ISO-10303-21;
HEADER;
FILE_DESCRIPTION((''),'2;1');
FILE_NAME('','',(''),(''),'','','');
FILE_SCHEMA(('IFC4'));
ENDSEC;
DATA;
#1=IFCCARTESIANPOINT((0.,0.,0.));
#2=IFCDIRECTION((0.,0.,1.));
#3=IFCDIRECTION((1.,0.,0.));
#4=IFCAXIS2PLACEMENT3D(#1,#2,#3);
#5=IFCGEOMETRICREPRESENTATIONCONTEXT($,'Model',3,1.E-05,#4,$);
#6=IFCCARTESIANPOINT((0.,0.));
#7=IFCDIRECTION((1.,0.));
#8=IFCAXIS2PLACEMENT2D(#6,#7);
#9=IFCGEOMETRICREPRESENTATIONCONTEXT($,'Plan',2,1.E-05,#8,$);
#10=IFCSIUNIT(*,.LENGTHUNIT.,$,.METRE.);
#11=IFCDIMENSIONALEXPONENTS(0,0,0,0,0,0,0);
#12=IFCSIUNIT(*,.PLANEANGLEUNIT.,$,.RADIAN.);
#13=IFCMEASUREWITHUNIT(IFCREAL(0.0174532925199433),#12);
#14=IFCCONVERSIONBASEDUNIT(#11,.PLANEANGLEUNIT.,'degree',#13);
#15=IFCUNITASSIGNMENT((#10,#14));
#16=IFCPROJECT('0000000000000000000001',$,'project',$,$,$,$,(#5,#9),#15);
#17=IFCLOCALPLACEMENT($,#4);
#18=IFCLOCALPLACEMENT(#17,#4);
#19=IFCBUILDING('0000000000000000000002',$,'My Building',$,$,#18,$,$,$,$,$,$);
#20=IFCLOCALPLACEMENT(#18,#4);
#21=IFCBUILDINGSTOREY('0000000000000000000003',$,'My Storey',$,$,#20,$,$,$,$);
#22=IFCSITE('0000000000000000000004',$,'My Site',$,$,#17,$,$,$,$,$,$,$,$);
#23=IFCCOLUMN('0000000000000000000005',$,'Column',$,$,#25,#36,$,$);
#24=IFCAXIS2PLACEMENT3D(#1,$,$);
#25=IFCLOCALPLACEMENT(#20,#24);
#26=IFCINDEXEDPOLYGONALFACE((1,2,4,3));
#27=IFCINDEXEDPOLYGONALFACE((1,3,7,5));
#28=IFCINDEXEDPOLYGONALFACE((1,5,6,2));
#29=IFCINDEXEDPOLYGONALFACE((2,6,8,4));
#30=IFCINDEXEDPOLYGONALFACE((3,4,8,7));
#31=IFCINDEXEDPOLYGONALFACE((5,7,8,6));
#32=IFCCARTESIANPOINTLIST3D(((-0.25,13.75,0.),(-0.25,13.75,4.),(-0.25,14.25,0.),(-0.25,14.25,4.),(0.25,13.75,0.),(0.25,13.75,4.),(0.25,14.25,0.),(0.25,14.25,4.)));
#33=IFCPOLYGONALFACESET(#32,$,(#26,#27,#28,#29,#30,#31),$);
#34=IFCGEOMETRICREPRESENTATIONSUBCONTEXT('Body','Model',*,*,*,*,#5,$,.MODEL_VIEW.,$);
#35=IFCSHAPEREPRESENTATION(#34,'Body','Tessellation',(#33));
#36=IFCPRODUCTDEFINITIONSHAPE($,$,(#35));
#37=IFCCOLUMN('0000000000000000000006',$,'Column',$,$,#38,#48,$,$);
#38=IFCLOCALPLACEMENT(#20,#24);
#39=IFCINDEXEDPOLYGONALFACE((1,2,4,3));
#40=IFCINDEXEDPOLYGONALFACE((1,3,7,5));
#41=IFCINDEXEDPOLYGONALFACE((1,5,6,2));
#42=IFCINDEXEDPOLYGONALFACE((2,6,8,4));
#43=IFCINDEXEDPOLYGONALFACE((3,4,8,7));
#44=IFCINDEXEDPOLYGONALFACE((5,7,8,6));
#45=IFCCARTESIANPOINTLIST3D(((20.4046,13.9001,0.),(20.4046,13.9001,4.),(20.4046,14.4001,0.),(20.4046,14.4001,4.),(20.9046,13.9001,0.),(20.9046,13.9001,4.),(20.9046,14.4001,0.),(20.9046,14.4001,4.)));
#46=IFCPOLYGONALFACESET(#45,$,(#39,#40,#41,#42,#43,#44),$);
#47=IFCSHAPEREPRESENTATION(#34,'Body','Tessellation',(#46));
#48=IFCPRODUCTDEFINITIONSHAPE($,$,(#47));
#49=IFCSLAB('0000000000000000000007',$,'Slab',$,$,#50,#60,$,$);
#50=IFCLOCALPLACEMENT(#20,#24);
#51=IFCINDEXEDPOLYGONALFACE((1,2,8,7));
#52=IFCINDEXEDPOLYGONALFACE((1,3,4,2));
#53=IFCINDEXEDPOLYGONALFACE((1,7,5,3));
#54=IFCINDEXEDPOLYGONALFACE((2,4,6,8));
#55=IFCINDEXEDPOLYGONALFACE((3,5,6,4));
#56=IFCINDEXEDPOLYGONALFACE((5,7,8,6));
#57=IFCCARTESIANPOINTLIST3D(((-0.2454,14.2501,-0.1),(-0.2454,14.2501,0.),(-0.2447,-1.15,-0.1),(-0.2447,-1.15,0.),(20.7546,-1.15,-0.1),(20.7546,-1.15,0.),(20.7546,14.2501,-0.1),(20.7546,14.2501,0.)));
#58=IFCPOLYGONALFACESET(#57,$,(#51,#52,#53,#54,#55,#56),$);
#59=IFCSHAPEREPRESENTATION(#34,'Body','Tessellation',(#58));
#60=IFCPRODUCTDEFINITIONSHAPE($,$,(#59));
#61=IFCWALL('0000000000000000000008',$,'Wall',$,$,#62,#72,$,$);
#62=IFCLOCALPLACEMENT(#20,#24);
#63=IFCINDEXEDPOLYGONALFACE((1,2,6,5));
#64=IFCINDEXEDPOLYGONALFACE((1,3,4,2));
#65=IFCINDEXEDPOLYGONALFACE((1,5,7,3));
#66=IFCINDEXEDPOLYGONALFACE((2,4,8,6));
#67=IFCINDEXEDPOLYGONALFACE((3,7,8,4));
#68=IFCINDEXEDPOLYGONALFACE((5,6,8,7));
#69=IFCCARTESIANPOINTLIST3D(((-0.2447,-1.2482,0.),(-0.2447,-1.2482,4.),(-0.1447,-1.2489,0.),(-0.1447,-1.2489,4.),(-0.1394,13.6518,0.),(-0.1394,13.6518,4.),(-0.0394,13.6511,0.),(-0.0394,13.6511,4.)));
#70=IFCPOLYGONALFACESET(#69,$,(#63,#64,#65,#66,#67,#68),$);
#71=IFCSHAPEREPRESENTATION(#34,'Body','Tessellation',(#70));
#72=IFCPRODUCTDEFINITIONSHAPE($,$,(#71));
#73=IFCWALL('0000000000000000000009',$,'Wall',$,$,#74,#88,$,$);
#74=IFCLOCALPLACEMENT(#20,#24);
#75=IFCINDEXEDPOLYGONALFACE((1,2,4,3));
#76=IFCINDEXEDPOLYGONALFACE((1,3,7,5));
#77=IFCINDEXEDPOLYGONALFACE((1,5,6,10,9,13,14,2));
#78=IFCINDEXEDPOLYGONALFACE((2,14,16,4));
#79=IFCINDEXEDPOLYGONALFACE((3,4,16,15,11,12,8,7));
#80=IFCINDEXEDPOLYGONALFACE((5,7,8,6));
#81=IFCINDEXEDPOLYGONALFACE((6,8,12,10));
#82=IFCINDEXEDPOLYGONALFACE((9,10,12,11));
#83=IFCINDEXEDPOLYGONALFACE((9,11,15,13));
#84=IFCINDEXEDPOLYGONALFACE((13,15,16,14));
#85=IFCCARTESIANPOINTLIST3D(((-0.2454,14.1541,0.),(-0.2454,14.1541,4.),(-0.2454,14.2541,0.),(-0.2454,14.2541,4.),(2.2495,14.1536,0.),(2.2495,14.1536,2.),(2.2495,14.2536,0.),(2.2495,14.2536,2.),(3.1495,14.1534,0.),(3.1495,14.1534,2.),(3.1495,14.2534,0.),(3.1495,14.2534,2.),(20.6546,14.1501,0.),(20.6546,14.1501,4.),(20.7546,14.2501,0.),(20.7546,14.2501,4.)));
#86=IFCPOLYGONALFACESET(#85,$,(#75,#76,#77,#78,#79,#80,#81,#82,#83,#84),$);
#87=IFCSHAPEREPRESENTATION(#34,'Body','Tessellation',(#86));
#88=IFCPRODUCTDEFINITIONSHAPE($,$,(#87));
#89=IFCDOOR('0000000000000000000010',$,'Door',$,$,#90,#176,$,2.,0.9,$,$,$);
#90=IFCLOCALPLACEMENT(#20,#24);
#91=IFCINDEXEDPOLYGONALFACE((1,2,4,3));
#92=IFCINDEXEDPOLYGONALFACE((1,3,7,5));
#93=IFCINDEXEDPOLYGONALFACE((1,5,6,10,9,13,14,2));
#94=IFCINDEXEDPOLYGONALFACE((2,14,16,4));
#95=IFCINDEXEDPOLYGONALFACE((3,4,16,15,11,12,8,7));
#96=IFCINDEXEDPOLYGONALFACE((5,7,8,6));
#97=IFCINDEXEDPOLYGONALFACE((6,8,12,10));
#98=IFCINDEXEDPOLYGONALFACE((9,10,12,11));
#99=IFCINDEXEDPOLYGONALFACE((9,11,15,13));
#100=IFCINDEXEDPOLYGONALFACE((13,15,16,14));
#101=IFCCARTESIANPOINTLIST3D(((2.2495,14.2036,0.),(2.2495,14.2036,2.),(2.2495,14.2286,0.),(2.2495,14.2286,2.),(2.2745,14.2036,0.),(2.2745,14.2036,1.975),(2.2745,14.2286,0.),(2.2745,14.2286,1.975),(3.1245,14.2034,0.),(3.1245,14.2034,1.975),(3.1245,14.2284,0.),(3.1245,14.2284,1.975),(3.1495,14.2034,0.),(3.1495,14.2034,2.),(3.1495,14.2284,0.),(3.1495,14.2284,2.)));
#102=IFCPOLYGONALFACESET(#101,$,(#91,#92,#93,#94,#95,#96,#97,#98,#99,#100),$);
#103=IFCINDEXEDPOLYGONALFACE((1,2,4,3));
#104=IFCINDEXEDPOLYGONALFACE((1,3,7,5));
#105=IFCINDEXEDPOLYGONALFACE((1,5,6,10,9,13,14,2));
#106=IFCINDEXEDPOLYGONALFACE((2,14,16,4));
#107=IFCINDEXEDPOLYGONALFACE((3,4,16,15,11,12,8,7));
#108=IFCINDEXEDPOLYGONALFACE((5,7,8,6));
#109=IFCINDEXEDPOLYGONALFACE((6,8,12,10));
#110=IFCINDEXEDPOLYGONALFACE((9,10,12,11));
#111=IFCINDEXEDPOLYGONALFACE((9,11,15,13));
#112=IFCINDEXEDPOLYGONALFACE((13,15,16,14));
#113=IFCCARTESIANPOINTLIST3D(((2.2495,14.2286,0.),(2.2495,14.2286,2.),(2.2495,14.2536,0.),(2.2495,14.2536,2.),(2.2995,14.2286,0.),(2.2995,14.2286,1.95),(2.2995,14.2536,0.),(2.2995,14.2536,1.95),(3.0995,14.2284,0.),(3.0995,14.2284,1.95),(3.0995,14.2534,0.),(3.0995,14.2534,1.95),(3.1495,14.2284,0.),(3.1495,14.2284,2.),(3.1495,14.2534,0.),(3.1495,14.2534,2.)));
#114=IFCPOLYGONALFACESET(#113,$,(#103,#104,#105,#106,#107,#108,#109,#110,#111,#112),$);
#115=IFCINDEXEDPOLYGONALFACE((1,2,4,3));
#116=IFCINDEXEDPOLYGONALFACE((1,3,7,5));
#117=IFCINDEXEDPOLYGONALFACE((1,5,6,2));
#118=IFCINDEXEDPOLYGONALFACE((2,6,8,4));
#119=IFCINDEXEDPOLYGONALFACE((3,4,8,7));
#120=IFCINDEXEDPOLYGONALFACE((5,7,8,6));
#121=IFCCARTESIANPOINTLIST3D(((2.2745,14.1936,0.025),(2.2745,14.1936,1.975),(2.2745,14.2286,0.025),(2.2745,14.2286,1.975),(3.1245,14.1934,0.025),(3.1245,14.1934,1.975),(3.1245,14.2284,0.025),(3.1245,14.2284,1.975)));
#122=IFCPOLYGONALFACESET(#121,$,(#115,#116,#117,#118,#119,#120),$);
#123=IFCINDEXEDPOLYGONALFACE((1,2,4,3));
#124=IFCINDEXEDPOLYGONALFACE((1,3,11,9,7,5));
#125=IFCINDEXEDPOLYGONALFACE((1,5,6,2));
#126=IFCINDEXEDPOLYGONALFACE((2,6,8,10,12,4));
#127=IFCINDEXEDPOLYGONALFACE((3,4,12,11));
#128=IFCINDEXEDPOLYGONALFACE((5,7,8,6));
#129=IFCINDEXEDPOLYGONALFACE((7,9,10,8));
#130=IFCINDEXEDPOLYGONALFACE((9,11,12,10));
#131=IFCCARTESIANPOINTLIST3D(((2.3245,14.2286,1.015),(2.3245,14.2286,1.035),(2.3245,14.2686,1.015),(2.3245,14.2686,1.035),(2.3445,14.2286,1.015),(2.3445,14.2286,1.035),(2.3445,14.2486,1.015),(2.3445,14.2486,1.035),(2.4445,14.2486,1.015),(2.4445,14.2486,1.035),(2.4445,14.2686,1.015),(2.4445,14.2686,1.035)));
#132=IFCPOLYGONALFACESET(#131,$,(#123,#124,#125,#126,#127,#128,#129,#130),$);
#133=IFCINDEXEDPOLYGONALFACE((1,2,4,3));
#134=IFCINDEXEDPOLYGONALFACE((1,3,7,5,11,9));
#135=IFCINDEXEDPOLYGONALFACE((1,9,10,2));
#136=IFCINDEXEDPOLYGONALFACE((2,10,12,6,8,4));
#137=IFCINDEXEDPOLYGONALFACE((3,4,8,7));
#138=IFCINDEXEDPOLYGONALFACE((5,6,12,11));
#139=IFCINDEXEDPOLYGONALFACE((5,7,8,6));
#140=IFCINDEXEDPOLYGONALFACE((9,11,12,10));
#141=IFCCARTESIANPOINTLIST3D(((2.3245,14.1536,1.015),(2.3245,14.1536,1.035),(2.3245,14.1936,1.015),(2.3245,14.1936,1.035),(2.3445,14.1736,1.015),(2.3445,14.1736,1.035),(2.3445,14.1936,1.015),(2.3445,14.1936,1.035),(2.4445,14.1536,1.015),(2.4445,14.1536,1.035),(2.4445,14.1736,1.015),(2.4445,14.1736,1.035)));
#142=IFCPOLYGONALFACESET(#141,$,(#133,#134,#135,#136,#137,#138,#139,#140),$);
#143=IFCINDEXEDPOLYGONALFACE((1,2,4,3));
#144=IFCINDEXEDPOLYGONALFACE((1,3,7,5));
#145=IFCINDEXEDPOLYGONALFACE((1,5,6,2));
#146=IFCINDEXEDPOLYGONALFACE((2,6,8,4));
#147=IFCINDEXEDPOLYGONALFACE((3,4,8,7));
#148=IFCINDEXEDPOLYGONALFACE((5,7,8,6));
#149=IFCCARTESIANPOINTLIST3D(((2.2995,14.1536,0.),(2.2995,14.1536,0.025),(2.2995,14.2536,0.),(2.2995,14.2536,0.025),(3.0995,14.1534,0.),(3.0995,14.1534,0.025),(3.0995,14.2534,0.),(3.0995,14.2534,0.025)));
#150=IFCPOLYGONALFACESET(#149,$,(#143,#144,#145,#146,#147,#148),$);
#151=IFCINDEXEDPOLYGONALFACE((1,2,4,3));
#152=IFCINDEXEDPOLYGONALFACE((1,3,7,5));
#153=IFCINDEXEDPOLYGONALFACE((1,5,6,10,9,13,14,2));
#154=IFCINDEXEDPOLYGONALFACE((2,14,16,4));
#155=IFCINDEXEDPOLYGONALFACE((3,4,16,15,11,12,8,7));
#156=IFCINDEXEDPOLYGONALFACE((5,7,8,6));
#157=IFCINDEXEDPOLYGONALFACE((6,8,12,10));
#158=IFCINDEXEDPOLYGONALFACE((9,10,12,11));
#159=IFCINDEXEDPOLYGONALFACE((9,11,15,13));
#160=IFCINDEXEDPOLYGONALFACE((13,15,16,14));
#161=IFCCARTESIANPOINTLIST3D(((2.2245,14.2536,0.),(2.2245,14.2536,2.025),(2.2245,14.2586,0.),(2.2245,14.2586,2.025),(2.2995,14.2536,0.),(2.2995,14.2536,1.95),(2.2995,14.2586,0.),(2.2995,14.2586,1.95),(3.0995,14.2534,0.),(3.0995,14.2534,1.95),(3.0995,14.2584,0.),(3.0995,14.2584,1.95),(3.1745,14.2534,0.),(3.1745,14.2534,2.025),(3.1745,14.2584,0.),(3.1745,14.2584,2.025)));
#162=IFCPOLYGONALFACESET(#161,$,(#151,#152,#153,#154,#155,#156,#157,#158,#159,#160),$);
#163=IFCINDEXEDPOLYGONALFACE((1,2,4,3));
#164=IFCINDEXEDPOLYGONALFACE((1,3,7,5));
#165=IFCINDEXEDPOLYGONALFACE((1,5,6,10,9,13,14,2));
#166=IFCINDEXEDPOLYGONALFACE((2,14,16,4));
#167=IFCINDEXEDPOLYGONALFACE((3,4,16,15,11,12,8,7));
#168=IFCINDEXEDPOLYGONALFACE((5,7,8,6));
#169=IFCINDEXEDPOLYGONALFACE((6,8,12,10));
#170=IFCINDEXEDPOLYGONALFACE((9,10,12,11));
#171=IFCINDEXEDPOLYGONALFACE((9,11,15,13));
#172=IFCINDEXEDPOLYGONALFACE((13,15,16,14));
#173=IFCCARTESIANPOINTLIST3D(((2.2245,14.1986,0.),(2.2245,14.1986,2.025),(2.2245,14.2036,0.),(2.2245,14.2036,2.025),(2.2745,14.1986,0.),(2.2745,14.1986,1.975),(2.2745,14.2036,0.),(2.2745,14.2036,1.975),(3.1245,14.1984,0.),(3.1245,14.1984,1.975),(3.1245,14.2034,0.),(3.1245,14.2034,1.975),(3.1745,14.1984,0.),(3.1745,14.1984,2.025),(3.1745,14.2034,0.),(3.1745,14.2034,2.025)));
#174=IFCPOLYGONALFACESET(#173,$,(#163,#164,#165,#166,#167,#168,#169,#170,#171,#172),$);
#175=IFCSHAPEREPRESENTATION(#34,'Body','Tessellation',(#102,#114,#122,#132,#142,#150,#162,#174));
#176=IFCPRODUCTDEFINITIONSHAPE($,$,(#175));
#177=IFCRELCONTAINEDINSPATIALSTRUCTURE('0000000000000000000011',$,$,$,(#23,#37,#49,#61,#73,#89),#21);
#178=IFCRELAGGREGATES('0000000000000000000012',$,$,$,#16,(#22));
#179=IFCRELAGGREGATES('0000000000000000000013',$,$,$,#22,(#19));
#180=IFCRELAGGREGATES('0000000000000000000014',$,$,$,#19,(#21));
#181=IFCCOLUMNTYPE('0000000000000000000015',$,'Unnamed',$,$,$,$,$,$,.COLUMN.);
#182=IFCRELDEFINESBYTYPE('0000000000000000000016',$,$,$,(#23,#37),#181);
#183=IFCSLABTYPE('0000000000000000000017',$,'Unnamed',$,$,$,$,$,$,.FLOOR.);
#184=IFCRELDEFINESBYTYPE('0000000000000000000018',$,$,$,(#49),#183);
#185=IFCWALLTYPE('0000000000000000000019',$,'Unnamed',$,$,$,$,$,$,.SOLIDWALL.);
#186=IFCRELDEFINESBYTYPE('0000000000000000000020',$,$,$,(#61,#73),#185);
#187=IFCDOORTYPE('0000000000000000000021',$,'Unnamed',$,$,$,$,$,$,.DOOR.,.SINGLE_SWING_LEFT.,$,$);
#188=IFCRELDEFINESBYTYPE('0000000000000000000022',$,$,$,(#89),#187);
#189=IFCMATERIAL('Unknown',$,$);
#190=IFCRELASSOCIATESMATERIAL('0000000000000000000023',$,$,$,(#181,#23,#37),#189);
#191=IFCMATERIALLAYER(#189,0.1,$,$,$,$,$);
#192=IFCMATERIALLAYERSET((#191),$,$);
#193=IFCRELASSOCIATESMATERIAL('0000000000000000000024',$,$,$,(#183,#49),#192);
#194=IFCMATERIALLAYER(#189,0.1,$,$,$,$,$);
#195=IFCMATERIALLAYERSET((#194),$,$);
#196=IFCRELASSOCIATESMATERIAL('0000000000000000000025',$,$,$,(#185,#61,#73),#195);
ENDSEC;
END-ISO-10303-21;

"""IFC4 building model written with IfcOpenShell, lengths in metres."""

from ifc_helpers import new_model, entity, si_unit, converted_unit, frame, origin_with_axes, origin_2d_with_axis, place, context, subcontext, project, spatial, line, indexed_curve, rectangle, outline, extrude, shape, source, transform, mapped, material, layer, layer_set, layer_usage, material_profile, profile_set, profile_usage, type_object, type_shapes, element, fill, save


model = new_model("IFC4")

# Units and contexts
model_context = context("Model", 3, precision=1e-05, world=origin_with_axes())
plan_context = context("Plan", 2, precision=1e-05, world=origin_2d_with_axis())
body_context_1 = subcontext(model_context, "Body", "Model", "MODEL_VIEW")
body_context_2 = subcontext(plan_context, "Body", "Plan", "PLAN_VIEW")
ifc_project = project(units=[si_unit("LENGTHUNIT", "METRE"), converted_unit("PLANEANGLEUNIT", "degree", entity("IfcReal", 0.0174532925199433), si_unit("PLANEANGLEUNIT", "RADIAN"), dimensions=[0, 0, 0, 0, 0, 0, 0])], contexts=[model_context, plan_context])

# Site, building, storey
site_placement = place(None, origin_with_axes())
site = spatial("IfcSite", under=ifc_project, at=site_placement, Name="My Site")
building_placement = place(site_placement, origin_with_axes())
building = spatial("IfcBuilding", under=site, at=building_placement, Name="My Building")
storey_placement = place(building_placement, origin_with_axes())
storey = spatial("IfcBuildingStorey", under=building, at=storey_placement, Name="My Storey")

# Columns
ifc_material = material(Name="Unknown")
ifc_material_profile_1 = material_profile(ifc_material, rectangle(XDim=0.5, YDim=0.5))
ifc_profile_set_1 = profile_set([ifc_material_profile_1])
ifc_profile_usage_1 = profile_usage(ifc_profile_set_1, cardinal=5)
column_type = type_object("IfcColumnType", Name="Unnamed", PredefinedType="COLUMN", material=ifc_profile_set_1)
column_1_placement = place(storey_placement, frame((0.0, 14.0, 0.0), z_axis=(0.0, 0.0, 1.0), x_axis=(1.0, 0.0, 0.0)))
element("IfcColumn", 1, at=column_1_placement, inside=storey, type_object=column_type, material=ifc_profile_usage_1, Name="Column", context=body_context_1, shape_type="SweptSolid", body=[
    extrude(rectangle(XDim=0.5, YDim=0.5), origin_with_axes(), (0.0, 0.0, 1.0), 4.0),
])
ifc_profile_usage_2 = profile_usage(ifc_profile_set_1, cardinal=5)
column_2_placement = place(storey_placement, frame((20.6546, 14.1501, 0.0), z_axis=(0.0, 0.0, 1.0), x_axis=(1.0, 0.0, 0.0)))
element("IfcColumn", 2, at=column_2_placement, inside=storey, type_object=column_type, material=ifc_profile_usage_2, Name="Column", context=body_context_1, shape_type="SweptSolid", body=[
    extrude(rectangle(XDim=0.5, YDim=0.5), origin_with_axes(), (0.0, 0.0, 1.0), 4.0),
])

# Slab
ifc_layer_1 = layer(ifc_material, 0.1)
ifc_layer_set_1 = layer_set([ifc_layer_1])
ifc_layer_usage_1 = layer_usage(ifc_layer_set_1, "AXIS3", "POSITIVE", -0.1)
slab_type = type_object("IfcSlabType", Name="Unnamed", PredefinedType="FLOOR", material=ifc_layer_set_1)
slab_placement = place(storey_placement, frame((-0.2454, 14.2501, 0.0), z_axis=(0.0, 0.0, 1.0), x_axis=(1.0, 0.0, 0.0)))
element("IfcSlab", 3, at=slab_placement, inside=storey, type_object=slab_type, material=ifc_layer_usage_1, Name="Slab", context=body_context_1, shape_type="SweptSolid", body=[
    extrude(outline(indexed_curve([(0.0, 0.0), (21.0, 0.0), (21.0, -15.4), (0.0007, -15.4), (0.0, 0.0)])), frame((0.0, 0.0, -0.1), z_axis=(0.0, 0.0, 1.0), x_axis=(1.0, 0.0, 0.0)), (0.0, 0.0, 1.0), 0.1),
])

# Wall
ifc_layer_2 = layer(ifc_material, 0.1)
ifc_layer_set_2 = layer_set([ifc_layer_2])
ifc_layer_usage_2 = layer_usage(ifc_layer_set_2, "AXIS2", "POSITIVE", 0.0)
wall_type = type_object("IfcWallType", Name="Unnamed", PredefinedType="SOLIDWALL", material=ifc_layer_set_2)
wall_1_placement = place(storey_placement, frame((-0.1394, 13.6518, 0.0), z_axis=(0.0, 0.0, 1.0), x_axis=(-0.007068, -0.999975, 0.0)))
element("IfcWall", 4, at=wall_1_placement, inside=storey, type_object=wall_type, material=ifc_layer_usage_2, Name="Wall", context=body_context_1, shape_type="SweptSolid", body=[
    extrude(outline(indexed_curve([(0.0, 0.0), (0.0, 0.1), (14.9004, 0.1), (14.9004, 0.0)], segments=[line(1, 2, 3, 4, 1)])), origin_with_axes(), (0.0, 0.0, 1.0), 4.0),
])

# Wall, opening, door
ifc_layer_usage_3 = layer_usage(ifc_layer_set_2, "AXIS2", "POSITIVE", 0.0)
wall_2_placement = place(storey_placement, frame((20.7546, 14.2501, 0.0), z_axis=(0.0, 0.0, 1.0), x_axis=(-1.0, 0.000191, 0.0)))
wall_2 = element("IfcWall", 5, at=wall_2_placement, inside=storey, type_object=wall_type, material=ifc_layer_usage_3, Name="Wall", context=body_context_1, shape_type="SweptSolid", body=[
    extrude(outline(indexed_curve([(0.0, 0.0), (0.1, 0.1), (21.0, 0.1), (21.0, 0.0)], segments=[line(1, 2, 3, 4, 1)])), origin_with_axes(), (0.0, 0.0, 1.0), 4.0),
])
shared_shape_1 = source(origin_with_axes(), body_context_1, "Body", "SweptSolid", [
    extrude(outline(indexed_curve([(0.0, 0.0), (0.9, 0.0), (0.9, 2.0), (0.0, 2.0)], segments=[line(1, 2, 3, 4, 1)])), frame((0.0, -0.6, 0.0), z_axis=(0.0, -1.0, 0.0), x_axis=(1.0, 0.0, 0.0)), (0.0, 0.0, -1.0), 1.2),
])
opening_1_placement = place(wall_2_placement, frame((17.6051, 0.0, 0.0), z_axis=(0.0, 0.0, 1.0), x_axis=(1.0, 0.0, 0.0)))
opening_1 = element("IfcOpeningElement", 6, at=opening_1_placement, cuts=wall_2, PredefinedType="OPENING", context=body_context_1, shape_type="MappedRepresentation", body=[
    mapped(shared_shape_1, transform((0.0, 0.0, 0.0), x_axis=(1.0, 0.0, 0.0), y_axis=(0.0, 1.0, 0.0), z_axis=(0.0, 0.0, 1.0), scale=1.0)),
])
door_type = type_object("IfcDoorType", Name="Unnamed", OperationType="SINGLE_SWING_LEFT", PredefinedType="DOOR")
shared_shape_2 = source(origin_with_axes(), body_context_1, "Body", "SweptSolid", [
    extrude(outline(indexed_curve([(0.0, 0.0), (0.0, 2.0), (0.9, 2.0), (0.9, 0.0), (0.875, 0.0), (0.875, 1.975), (0.025, 1.975), (0.025, 0.0)], segments=[line(1, 2, 3, 4, 5, 6, 7, 8, 1)])), frame((0.0, 0.025, 0.0), z_axis=(0.0, -1.0, 0.0), x_axis=(1.0, 0.0, 0.0)), (0.0, 0.0, -1.0), 0.025),
    extrude(outline(indexed_curve([(0.0, 0.0), (0.0, 2.0), (0.9, 2.0), (0.9, 0.0), (0.85, 0.0), (0.85, 1.95), (0.05, 1.95), (0.05, 0.0)], segments=[line(1, 2, 3, 4, 5, 6, 7, 8, 1)])), frame((0.0, 0.0, 0.0), z_axis=(0.0, -1.0, 0.0), x_axis=(1.0, 0.0, 0.0)), (0.0, 0.0, -1.0), 0.025),
    extrude(outline(indexed_curve([(0.0, 0.0), (0.85, 0.0), (0.85, 0.035), (0.0, 0.035)], segments=[line(1, 2, 3, 4, 1)])), frame((0.025, 0.025, 0.025), z_axis=(0.0, 0.0, 1.0), x_axis=(1.0, 0.0, 0.0)), (0.0, 0.0, 1.0), 1.95),
    extrude(outline(indexed_curve([(0.0, 0.0), (0.0, -0.04), (-0.12, -0.04), (-0.12, -0.02), (-0.02, -0.02), (-0.02, 0.0)], segments=[line(1, 2, 3, 4, 5, 6, 1)])), frame((0.825, 0.025, 1.015), z_axis=(0.0, 0.0, 1.0), x_axis=(1.0, 0.0, 0.0)), (0.0, 0.0, 1.0), 0.02),
    extrude(outline(indexed_curve([(0.0, 0.0), (0.0, 0.04), (-0.12, 0.04), (-0.12, 0.02), (-0.02, 0.02), (-0.02, 0.0)], segments=[line(1, 2, 3, 4, 5, 6, 1)])), frame((0.825, 0.06, 1.015), z_axis=(0.0, 0.0, 1.0), x_axis=(1.0, 0.0, 0.0)), (0.0, 0.0, 1.0), 0.02),
    extrude(outline(indexed_curve([(0.0, 0.0), (0.8, 0.0), (0.8, 0.1), (0.0, 0.1)], segments=[line(1, 2, 3, 4, 1)])), frame((0.05, 0.0, 0.0), z_axis=(0.0, 0.0, 1.0), x_axis=(1.0, 0.0, 0.0)), (0.0, 0.0, 1.0), 0.025),
    extrude(outline(indexed_curve([(0.0, 0.0), (0.0, 2.025), (0.95, 2.025), (0.95, 0.0), (0.875, 0.0), (0.875, 1.95), (0.075, 1.95), (0.075, 0.0)], segments=[line(1, 2, 3, 4, 5, 6, 7, 8, 1)])), frame((-0.025, -0.005, 0.0), z_axis=(0.0, -1.0, 0.0), x_axis=(1.0, 0.0, 0.0)), (0.0, 0.0, -1.0), 0.005),
    extrude(outline(indexed_curve([(0.0, 0.0), (0.0, 2.025), (0.95, 2.025), (0.95, 0.0), (0.9, 0.0), (0.9, 1.975), (0.05, 1.975), (0.05, 0.0)], segments=[line(1, 2, 3, 4, 5, 6, 7, 8, 1)])), frame((-0.025, 0.05, 0.0), z_axis=(0.0, -1.0, 0.0), x_axis=(1.0, 0.0, 0.0)), (0.0, 0.0, -1.0), 0.005),
])
shared_shape_3 = source(origin_with_axes(), body_context_2, "Body", "Curve2D", [
    entity("IfcIndexedPolyCurve", entity("IfcCartesianPointList2D", [[0.0, 0.0], [0.0, 0.05], [0.025, 0.05], [0.025, 0.025], [0.05, 0.025], [0.05, 0.0]]), [entity("IfcLineIndex", [1, 2, 3, 4, 5, 6, 1])]),
    entity("IfcIndexedPolyCurve", entity("IfcCartesianPointList2D", [[0.9, 0.0], [0.9, 0.05], [0.875, 0.05], [0.875, 0.025], [0.85, 0.025], [0.85, 0.0]]), [entity("IfcLineIndex", [1, 2, 3, 4, 5, 6, 1])]),
    entity("IfcTrimmedCurve", entity("IfcEllipse", entity("IfcAxis2Placement2D", entity("IfcCartesianPoint", [0.06, 0.05]), entity("IfcDirection", [1.0, 0.0])), 0.815, 0.85), [entity("IfcCartesianPoint", [0.875, 0.05])], [entity("IfcCartesianPoint", [0.06, 0.9])], True, "CARTESIAN"),
    entity("IfcIndexedPolyCurve", entity("IfcCartesianPointList2D", [[0.025, 0.05], [0.06, 0.05], [0.06, 0.9], [0.025, 0.9]]), [entity("IfcLineIndex", [1, 2, 3, 4, 1])]),
])
type_shapes(door_type, [shared_shape_2, shared_shape_3])
door_1_placement = place(opening_1_placement, origin_with_axes())
door_1 = element("IfcDoor", 7, at=door_1_placement, inside=storey, type_object=door_type, Name="Door", OverallHeight=2.0, OverallWidth=0.9, shapes=[
    shape(body_context_1, "Body", "MappedRepresentation", [mapped(shared_shape_2, transform((0.0, 0.0, 0.0), x_axis=(1.0, 0.0, 0.0), y_axis=(0.0, 1.0, 0.0), z_axis=(0.0, 0.0, 1.0), scale=1.0))]),
    shape(body_context_2, "Body", "MappedRepresentation", [mapped(shared_shape_3, transform((0.0, 0.0, 0.0), x_axis=(1.0, 0.0, 0.0), y_axis=(0.0, 1.0, 0.0), z_axis=(0.0, 0.0, 1.0), scale=1.0))]),
])
fill(opening_1, door_1)

save(model, "model.ifc")
